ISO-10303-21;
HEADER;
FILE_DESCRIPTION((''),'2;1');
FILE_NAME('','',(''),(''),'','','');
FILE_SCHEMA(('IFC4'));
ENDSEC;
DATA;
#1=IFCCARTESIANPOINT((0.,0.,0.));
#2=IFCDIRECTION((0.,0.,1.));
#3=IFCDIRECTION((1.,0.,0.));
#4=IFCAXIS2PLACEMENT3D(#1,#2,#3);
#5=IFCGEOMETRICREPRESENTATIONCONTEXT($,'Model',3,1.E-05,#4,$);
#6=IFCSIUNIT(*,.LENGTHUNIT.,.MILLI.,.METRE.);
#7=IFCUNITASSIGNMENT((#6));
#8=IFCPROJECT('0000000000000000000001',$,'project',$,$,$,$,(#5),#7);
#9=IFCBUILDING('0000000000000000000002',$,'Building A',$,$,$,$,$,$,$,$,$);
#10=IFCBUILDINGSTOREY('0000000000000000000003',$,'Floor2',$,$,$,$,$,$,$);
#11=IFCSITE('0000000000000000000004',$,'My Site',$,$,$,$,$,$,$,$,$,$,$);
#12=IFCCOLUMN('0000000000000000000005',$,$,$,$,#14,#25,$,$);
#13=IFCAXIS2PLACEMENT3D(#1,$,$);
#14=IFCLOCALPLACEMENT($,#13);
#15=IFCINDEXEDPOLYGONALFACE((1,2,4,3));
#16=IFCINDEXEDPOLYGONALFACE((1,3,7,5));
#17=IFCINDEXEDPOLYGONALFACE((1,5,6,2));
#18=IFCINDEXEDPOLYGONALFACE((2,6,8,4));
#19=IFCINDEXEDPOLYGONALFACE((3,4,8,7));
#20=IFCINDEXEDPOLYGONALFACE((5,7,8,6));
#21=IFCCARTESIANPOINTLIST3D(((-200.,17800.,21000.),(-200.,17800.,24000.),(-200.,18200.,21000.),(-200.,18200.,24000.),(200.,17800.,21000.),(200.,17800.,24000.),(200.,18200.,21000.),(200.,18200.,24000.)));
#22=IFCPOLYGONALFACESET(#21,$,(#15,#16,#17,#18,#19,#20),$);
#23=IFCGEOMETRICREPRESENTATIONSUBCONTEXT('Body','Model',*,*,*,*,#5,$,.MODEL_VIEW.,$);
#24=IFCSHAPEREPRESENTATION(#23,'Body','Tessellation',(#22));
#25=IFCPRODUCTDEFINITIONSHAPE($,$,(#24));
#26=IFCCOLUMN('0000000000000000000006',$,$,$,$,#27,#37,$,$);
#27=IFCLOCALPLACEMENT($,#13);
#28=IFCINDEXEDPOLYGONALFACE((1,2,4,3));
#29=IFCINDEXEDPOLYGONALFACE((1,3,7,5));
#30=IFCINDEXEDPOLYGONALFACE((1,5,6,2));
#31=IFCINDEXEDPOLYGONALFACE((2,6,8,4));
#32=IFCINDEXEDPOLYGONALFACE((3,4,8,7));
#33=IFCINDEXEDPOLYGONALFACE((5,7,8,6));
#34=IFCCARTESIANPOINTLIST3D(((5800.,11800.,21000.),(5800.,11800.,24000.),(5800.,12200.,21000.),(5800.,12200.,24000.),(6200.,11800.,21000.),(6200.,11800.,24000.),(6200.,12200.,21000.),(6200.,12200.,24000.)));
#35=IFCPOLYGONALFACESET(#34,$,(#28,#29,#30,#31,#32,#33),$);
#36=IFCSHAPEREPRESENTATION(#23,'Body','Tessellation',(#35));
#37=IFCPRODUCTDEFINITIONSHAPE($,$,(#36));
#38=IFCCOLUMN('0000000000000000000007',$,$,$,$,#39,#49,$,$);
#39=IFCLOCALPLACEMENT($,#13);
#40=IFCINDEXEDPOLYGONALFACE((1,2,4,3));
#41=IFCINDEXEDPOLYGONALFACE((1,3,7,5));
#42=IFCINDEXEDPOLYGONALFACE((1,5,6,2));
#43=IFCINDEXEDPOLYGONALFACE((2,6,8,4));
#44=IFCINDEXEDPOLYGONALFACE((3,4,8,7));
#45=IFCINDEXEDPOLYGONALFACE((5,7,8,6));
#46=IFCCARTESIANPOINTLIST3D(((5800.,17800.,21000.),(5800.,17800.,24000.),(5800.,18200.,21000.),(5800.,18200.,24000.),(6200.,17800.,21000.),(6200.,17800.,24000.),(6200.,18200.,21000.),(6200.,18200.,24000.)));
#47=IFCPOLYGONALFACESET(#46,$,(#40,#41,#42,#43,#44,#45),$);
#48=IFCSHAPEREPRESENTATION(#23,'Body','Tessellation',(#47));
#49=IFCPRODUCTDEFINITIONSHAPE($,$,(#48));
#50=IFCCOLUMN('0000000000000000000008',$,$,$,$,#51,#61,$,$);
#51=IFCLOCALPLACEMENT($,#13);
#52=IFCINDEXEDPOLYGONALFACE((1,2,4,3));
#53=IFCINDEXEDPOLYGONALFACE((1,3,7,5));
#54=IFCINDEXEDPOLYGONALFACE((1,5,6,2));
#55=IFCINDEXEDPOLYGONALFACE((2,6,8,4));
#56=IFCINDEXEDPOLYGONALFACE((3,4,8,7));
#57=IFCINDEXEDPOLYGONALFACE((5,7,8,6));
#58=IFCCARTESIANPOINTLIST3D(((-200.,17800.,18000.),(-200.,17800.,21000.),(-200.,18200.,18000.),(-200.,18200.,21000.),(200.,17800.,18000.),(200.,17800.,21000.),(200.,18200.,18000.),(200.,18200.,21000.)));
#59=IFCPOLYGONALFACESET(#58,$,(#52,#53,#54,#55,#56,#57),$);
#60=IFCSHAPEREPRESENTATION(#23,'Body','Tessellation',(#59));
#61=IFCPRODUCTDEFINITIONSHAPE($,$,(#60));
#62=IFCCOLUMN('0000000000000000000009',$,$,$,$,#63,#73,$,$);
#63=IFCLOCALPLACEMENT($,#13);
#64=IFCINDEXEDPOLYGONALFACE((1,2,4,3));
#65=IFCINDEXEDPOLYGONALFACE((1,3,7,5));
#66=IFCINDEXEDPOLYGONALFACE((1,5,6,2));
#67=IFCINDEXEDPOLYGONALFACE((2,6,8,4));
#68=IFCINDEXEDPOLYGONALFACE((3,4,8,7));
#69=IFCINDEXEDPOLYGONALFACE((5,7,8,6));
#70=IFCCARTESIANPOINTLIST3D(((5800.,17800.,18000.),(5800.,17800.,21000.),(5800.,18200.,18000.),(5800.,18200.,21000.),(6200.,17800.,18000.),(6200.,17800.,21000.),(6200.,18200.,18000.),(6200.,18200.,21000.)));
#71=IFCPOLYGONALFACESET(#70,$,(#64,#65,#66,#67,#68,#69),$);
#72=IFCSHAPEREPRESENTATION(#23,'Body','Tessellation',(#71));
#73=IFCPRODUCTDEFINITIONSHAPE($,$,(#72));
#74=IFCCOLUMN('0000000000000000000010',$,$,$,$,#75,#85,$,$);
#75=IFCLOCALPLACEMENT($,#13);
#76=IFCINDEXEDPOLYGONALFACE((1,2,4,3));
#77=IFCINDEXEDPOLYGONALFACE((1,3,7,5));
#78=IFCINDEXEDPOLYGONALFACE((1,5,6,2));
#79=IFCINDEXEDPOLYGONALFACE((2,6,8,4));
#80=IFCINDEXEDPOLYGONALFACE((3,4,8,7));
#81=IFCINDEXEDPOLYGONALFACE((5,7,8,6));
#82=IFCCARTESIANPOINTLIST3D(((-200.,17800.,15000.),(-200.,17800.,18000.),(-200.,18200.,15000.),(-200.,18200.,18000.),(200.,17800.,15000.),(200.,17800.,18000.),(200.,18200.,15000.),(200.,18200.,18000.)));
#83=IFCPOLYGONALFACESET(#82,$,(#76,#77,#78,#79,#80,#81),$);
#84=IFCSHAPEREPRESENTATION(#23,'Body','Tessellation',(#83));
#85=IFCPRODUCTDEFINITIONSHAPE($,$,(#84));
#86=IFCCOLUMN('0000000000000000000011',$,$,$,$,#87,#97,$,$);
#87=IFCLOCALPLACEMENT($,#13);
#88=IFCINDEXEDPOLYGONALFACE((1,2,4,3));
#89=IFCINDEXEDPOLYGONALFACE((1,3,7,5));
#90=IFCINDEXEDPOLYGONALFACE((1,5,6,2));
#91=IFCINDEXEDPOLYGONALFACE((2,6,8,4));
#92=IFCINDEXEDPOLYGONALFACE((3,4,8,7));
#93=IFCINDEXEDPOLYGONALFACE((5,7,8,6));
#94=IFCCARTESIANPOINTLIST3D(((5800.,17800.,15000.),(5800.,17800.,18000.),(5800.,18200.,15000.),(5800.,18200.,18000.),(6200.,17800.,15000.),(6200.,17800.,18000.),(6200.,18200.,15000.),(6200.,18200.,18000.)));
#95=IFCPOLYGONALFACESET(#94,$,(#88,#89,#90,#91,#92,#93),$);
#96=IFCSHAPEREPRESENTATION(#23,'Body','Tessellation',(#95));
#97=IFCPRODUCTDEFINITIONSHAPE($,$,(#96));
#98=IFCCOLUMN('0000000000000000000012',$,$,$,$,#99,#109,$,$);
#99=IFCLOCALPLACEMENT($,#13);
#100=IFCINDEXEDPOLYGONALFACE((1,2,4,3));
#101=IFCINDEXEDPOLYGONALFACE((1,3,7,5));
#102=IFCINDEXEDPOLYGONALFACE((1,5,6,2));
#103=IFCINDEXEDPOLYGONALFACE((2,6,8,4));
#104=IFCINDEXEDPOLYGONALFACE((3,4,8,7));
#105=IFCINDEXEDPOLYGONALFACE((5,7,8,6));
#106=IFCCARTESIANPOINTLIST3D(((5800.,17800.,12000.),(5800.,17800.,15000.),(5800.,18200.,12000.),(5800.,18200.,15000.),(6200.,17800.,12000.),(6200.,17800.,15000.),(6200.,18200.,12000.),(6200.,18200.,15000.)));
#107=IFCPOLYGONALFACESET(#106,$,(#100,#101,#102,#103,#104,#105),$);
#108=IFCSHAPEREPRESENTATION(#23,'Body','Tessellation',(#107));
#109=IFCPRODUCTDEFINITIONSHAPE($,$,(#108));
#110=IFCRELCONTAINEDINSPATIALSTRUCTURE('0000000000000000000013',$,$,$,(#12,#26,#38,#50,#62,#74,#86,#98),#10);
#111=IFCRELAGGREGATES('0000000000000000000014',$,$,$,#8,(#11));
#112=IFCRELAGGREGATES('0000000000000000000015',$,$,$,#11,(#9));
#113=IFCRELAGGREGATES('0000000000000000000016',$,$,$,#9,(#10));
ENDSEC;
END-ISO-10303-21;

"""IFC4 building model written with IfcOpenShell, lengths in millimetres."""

from ifc_helpers import new_model, si_unit, frame, origin_with_axes, place, context, subcontext, project, spatial, line, indexed_curve, outline, extrude, element, save


model = new_model("IFC4")

# Units and contexts
model_context = context("Model", 3, precision=1e-05, world=origin_with_axes())
body_context = subcontext(model_context, "Body", "Model", "MODEL_VIEW")
ifc_project = project(units=[si_unit("LENGTHUNIT", "METRE", prefix="MILLI")], contexts=[model_context])

# Site, building, storey
site = spatial("IfcSite", under=ifc_project, Name="My Site")
building = spatial("IfcBuilding", under=site, Name="Building A")
storey = spatial("IfcBuildingStorey", under=building, Name="Floor2")

# Columns
for number, where, z_axis, x_axis in (
    (1, (0.0, 18000.0, 21000.0), (0.0, 0.0, 1.0), (1.0, 0.0, 0.0)),
    (2, (6000.0, 12000.0, 21000.0), (0.0, 0.0, 1.0), (1.0, 0.0, 0.0)),
    (3, (6000.0, 18000.0, 21000.0), (0.0, 0.0, 1.0), (1.0, 0.0, 0.0)),
    (4, (0.0, 18000.0, 18000.0), (0.0, 0.0, 1.0), (1.0, 0.0, 0.0)),
    (5, (6000.0, 18000.0, 18000.0), (0.0, 0.0, 1.0), (1.0, 0.0, 0.0)),
    (6, (0.0, 18000.0, 15000.0), (0.0, 0.0, 1.0), (1.0, 0.0, 0.0)),
    (7, (6000.0, 18000.0, 15000.0), (0.0, 0.0, 1.0), (1.0, 0.0, 0.0)),
    (8, (6000.0, 18000.0, 12000.0), (0.0, 0.0, 1.0), (1.0, 0.0, 0.0)),
):
    element("IfcColumn", number, at=place(None, frame(where, z_axis=z_axis, x_axis=x_axis)), inside=storey, context=body_context, shape_type="SweptSolid", body=[
        extrude(outline(indexed_curve([(-200.0, -200.0), (200.0, -200.0), (200.0, 200.0), (-200.0, 200.0)], segments=[line(1, 2, 3, 4, 1)])), origin_with_axes(), (0.0, 0.0, 1.0), 3000.0),
    ])

save(model, "model.ifc")
